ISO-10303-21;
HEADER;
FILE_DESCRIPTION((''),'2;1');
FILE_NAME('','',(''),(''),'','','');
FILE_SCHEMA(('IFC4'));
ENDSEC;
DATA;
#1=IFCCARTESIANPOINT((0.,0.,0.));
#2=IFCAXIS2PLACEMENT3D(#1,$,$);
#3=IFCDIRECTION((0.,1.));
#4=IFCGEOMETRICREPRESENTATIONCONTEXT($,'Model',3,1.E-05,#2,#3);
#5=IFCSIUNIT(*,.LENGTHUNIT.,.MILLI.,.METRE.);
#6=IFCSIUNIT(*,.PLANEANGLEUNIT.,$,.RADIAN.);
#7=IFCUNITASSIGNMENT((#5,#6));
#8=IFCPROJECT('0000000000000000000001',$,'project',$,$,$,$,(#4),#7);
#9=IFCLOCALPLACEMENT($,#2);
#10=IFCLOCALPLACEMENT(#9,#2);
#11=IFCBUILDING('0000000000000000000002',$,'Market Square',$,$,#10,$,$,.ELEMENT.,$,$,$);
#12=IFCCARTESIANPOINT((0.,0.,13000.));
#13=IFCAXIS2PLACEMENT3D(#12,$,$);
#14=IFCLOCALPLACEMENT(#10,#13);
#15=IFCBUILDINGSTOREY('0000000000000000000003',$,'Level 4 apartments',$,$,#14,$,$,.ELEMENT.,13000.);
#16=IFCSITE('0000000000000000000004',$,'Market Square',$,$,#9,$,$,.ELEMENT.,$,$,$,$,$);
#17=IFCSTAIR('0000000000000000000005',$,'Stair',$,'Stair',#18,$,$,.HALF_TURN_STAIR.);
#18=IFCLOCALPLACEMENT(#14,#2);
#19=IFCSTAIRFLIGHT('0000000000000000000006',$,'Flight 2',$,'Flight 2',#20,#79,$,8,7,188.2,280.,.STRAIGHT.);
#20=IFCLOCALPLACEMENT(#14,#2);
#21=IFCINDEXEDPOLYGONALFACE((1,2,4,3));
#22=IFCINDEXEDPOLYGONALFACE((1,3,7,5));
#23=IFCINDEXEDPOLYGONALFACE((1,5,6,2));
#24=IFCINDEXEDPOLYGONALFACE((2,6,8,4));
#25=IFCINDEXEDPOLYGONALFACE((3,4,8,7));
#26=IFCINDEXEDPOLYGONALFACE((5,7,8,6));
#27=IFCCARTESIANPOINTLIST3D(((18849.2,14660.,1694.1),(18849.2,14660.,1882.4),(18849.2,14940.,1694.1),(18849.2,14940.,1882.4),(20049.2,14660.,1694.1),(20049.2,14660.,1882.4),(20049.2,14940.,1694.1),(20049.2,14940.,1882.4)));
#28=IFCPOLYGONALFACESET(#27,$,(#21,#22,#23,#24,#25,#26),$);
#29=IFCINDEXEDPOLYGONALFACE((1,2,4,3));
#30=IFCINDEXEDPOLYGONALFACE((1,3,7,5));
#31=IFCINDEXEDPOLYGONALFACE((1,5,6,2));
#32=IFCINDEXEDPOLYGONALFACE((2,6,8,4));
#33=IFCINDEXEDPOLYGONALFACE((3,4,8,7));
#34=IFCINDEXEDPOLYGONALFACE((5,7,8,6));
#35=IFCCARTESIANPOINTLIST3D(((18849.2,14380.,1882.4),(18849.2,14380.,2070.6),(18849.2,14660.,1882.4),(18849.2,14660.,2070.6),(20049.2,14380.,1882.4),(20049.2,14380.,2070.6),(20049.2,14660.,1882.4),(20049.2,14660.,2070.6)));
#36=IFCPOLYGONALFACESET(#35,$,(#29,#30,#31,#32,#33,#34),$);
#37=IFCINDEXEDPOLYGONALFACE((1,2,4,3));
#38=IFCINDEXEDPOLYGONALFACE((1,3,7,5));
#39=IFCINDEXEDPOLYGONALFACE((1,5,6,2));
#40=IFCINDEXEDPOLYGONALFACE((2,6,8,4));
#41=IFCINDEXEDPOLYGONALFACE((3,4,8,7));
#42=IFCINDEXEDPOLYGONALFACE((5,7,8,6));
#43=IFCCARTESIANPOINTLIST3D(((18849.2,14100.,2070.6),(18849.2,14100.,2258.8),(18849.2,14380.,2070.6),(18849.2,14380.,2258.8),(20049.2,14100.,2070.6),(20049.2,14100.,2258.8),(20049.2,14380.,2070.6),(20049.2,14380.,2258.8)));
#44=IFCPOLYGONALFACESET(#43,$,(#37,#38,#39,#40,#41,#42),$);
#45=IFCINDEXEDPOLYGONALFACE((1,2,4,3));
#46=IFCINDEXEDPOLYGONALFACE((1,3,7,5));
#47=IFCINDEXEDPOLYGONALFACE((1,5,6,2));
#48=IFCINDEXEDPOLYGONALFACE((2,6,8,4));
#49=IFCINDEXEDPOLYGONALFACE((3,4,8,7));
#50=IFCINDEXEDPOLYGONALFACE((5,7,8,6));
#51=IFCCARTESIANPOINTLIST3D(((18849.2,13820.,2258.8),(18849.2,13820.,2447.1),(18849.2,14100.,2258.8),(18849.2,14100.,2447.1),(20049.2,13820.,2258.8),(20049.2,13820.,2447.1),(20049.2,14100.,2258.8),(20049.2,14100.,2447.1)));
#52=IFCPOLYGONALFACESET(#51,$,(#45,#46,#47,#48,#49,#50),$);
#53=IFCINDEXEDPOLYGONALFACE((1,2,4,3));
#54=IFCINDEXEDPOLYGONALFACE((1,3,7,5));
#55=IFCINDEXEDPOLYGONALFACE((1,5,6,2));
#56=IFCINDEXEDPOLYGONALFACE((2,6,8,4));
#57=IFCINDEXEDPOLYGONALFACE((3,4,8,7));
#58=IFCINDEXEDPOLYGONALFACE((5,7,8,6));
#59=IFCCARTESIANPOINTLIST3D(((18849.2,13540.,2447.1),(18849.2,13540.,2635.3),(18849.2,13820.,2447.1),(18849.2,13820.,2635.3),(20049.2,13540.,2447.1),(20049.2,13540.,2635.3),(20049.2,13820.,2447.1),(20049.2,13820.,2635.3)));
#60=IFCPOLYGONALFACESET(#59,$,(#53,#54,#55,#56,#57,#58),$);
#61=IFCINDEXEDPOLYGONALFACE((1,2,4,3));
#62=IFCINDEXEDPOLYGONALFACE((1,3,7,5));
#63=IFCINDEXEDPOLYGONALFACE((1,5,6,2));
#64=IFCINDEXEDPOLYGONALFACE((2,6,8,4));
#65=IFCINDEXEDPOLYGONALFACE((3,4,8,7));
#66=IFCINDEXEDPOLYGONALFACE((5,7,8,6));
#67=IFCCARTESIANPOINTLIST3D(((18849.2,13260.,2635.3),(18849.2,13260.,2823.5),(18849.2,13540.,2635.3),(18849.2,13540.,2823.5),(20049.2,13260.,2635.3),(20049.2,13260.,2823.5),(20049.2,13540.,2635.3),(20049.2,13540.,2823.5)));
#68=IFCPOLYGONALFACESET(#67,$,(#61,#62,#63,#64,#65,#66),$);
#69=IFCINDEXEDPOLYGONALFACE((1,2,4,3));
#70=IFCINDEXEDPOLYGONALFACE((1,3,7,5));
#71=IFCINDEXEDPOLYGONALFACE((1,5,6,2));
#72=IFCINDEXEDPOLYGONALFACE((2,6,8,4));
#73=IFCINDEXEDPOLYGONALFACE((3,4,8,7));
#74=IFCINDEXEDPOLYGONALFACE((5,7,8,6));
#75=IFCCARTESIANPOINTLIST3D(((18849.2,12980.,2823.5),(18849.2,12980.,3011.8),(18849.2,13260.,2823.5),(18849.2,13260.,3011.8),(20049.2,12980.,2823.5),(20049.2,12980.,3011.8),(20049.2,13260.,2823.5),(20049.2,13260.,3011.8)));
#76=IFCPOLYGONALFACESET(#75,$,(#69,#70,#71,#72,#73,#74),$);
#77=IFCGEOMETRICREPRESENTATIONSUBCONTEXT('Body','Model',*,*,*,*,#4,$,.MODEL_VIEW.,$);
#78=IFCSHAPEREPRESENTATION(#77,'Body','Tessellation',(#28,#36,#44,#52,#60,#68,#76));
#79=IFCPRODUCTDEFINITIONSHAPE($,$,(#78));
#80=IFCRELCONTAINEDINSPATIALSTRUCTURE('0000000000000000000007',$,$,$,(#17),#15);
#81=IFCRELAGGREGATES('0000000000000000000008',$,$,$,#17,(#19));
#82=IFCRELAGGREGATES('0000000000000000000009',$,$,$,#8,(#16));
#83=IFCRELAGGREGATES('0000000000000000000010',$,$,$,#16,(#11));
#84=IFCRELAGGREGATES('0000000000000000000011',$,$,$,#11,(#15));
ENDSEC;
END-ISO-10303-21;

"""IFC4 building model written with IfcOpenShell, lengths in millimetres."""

from ifc_helpers import new_model, si_unit, direction, frame, origin, origin_with_axes, place, context, subcontext, project, spatial, polyline, outline, extrude, element, aggregate, save


model = new_model("IFC4")

# Units and contexts
model_context = context("Model", 3, precision=1e-05, world=origin(), true_north=direction((0.0, 1.0)))
body_context = subcontext(model_context, "Body", "Model", "MODEL_VIEW")
ifc_project = project(units=[si_unit("LENGTHUNIT", "METRE", prefix="MILLI"), si_unit("PLANEANGLEUNIT", "RADIAN")], contexts=[model_context])

# Site, building, storey
site_placement = place(None, origin())
site = spatial("IfcSite", under=ifc_project, at=site_placement, Name="Market Square", CompositionType="ELEMENT")
building_placement = place(site_placement, origin())
building = spatial("IfcBuilding", under=site, at=building_placement, Name="Market Square", CompositionType="ELEMENT")
storey_placement = place(building_placement, frame((0.0, 0.0, 13000.0)))
storey = spatial("IfcBuildingStorey", under=building, at=storey_placement, Name="Level 4 apartments", CompositionType="ELEMENT", Elevation=13000.0)

# Stair
stair_placement = place(storey_placement, origin_with_axes())
stair = element("IfcStair", 1, at=stair_placement, inside=storey, Name="Stair", ObjectType="Stair", PredefinedType="HALF_TURN_STAIR")

# Stair flight
stair_flight_placement = place(storey_placement, origin_with_axes())
stair_flight = element("IfcStairFlight", 2, at=stair_flight_placement, Name="Flight 2", ObjectType="Flight 2", NumberOfRisers=8, NumberOfTreads=7, PredefinedType="STRAIGHT", RiserHeight=188.2, TreadLength=280.0, context=body_context, shape_type="SweptSolid", body=[
    extrude(outline(polyline([(20049.2, 14660.0), (20049.2, 14940.0), (18849.2, 14940.0), (18849.2, 14660.0), (20049.2, 14660.0)])), frame((0.0, 0.0, 1694.1)), (0.0, 0.0, 1.0), 188.2),
    extrude(outline(polyline([(20049.2, 14380.0), (20049.2, 14660.0), (18849.2, 14660.0), (18849.2, 14380.0), (20049.2, 14380.0)])), frame((0.0, 0.0, 1882.4)), (0.0, 0.0, 1.0), 188.2),
    extrude(outline(polyline([(20049.2, 14100.0), (20049.2, 14380.0), (18849.2, 14380.0), (18849.2, 14100.0), (20049.2, 14100.0)])), frame((0.0, 0.0, 2070.6)), (0.0, 0.0, 1.0), 188.2),
    extrude(outline(polyline([(20049.2, 13820.0), (20049.2, 14100.0), (18849.2, 14100.0), (18849.2, 13820.0), (20049.2, 13820.0)])), frame((0.0, 0.0, 2258.8)), (0.0, 0.0, 1.0), 188.2),
    extrude(outline(polyline([(20049.2, 13540.0), (20049.2, 13820.0), (18849.2, 13820.0), (18849.2, 13540.0), (20049.2, 13540.0)])), frame((0.0, 0.0, 2447.1)), (0.0, 0.0, 1.0), 188.2),
    extrude(outline(polyline([(20049.2, 13260.0), (20049.2, 13540.0), (18849.2, 13540.0), (18849.2, 13260.0), (20049.2, 13260.0)])), frame((0.0, 0.0, 2635.3)), (0.0, 0.0, 1.0), 188.2),
    extrude(outline(polyline([(20049.2, 12980.0), (20049.2, 13260.0), (18849.2, 13260.0), (18849.2, 12980.0), (20049.2, 12980.0)])), frame((0.0, 0.0, 2823.5)), (0.0, 0.0, 1.0), 188.2),
])

aggregate(stair, [stair_flight])

save(model, "model.ifc")
